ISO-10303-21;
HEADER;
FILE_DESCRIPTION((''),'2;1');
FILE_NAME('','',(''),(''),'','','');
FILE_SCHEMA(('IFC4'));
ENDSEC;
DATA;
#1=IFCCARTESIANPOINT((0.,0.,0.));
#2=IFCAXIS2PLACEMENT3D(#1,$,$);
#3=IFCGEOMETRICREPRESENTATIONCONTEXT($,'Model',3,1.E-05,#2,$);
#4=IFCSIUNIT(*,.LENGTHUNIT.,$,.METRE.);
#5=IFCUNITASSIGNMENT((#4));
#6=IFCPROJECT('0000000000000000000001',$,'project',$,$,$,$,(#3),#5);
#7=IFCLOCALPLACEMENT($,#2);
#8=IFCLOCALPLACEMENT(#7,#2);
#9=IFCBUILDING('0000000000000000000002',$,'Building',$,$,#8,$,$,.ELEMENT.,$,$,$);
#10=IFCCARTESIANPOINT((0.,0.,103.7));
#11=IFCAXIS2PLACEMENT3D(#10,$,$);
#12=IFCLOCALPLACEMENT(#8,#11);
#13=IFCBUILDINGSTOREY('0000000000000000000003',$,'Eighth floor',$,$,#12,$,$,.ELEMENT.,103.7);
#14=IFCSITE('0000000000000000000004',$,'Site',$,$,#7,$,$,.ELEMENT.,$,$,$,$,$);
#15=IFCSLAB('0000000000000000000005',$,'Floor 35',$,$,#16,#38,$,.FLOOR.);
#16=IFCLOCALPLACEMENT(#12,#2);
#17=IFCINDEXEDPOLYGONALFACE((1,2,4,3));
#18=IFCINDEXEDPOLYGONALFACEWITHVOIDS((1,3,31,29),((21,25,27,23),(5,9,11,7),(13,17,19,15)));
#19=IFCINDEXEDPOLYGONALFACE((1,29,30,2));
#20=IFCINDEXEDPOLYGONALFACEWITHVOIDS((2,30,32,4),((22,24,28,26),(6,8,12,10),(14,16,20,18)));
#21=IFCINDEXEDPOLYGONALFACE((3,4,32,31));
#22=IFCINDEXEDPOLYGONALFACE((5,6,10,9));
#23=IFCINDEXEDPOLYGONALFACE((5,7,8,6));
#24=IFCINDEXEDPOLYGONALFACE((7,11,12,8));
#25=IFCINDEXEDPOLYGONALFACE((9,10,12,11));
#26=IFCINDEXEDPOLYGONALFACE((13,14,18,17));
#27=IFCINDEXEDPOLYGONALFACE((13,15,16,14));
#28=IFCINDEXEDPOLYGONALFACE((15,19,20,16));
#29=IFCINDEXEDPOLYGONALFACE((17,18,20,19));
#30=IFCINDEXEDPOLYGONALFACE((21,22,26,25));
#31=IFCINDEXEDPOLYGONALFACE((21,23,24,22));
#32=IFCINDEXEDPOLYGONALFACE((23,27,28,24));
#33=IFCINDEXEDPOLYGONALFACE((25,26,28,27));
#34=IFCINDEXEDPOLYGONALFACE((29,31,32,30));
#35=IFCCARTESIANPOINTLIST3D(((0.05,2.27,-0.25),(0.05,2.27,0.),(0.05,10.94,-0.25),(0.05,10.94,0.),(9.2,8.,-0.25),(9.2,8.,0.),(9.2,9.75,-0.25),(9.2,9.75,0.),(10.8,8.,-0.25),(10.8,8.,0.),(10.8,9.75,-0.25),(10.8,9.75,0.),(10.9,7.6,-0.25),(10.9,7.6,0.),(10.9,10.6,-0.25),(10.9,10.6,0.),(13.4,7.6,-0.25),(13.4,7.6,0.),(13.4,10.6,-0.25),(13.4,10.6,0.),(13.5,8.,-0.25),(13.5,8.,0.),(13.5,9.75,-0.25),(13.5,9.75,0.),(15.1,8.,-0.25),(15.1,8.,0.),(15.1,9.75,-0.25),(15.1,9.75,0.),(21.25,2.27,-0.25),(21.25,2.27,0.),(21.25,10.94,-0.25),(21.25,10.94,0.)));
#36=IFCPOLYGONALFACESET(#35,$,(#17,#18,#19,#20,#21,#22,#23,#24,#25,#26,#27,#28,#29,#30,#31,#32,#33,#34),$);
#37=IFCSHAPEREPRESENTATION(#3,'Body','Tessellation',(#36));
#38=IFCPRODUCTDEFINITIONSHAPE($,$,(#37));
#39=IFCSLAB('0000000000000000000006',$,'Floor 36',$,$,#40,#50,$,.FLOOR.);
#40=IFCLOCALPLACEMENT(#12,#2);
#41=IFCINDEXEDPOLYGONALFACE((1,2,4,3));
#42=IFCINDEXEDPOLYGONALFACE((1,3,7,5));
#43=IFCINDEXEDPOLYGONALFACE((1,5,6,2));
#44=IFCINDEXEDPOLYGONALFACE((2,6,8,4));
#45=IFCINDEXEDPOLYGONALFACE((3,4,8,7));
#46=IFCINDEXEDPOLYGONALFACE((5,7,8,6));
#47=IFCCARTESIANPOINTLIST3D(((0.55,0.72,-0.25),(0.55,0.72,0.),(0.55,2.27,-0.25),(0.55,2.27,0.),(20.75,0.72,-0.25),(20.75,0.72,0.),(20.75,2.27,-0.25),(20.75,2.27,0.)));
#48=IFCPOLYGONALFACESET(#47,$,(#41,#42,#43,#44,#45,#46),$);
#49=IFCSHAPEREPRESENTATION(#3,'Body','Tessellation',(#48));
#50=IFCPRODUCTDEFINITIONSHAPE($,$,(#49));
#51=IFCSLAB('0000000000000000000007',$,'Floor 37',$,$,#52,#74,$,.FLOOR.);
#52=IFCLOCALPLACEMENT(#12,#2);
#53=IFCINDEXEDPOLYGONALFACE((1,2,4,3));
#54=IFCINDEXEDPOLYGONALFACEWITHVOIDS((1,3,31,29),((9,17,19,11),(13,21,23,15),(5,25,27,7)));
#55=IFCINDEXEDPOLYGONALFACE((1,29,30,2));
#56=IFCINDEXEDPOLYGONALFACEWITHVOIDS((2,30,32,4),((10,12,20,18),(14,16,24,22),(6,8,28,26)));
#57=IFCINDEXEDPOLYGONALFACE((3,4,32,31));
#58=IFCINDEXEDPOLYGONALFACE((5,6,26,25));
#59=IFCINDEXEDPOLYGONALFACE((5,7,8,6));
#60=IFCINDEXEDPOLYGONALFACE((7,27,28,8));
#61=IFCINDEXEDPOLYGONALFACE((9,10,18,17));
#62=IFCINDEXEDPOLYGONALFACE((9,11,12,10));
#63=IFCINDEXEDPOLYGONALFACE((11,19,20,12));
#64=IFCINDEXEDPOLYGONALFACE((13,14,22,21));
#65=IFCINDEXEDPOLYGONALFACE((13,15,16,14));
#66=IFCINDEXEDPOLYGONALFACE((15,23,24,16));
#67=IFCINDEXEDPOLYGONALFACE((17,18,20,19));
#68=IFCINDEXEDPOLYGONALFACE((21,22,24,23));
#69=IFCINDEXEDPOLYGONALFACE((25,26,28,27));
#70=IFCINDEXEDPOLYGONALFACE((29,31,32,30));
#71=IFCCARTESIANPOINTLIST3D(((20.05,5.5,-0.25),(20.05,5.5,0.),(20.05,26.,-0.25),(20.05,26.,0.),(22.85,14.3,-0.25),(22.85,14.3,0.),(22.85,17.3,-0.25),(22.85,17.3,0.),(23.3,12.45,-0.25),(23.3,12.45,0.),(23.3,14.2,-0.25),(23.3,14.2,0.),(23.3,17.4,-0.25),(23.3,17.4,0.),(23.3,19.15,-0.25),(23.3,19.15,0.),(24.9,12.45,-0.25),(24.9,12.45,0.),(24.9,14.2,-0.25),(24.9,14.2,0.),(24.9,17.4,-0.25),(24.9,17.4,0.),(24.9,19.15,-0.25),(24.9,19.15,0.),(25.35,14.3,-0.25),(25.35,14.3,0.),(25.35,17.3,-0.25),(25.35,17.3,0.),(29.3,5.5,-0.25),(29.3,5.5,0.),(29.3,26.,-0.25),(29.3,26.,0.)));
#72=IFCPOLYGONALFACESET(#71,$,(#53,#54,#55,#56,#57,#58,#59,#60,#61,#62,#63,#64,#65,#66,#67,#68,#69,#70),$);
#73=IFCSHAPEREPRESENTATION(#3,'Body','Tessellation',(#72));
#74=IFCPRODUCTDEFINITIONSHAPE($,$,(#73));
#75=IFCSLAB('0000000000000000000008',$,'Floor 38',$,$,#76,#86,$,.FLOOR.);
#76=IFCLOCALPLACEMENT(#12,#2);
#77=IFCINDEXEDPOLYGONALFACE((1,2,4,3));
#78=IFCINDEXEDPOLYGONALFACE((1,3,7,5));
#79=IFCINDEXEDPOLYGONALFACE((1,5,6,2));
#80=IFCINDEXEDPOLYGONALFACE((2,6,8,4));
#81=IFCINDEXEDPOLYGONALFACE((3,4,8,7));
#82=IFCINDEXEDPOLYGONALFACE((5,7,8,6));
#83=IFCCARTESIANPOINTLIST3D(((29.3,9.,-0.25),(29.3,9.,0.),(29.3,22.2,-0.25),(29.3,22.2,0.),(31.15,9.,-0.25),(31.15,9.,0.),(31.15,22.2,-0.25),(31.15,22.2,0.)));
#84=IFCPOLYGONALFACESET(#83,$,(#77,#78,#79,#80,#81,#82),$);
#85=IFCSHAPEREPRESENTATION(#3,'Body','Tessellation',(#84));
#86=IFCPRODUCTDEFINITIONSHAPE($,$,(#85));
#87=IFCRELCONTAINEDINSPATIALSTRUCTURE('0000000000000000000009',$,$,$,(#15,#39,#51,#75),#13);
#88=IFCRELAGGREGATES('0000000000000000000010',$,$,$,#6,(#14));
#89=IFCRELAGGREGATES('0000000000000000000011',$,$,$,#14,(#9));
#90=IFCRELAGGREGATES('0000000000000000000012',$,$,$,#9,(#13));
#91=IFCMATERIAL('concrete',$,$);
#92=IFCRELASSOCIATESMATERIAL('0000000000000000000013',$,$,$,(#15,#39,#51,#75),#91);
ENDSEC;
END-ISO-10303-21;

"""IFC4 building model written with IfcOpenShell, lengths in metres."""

from ifc_helpers import new_model, si_unit, frame, origin, place, context, project, spatial, polyline, outline, extrude, material, element, save


model = new_model("IFC4")

# Units and contexts
model_context = context("Model", 3, precision=1e-05, world=origin())
ifc_project = project(units=[si_unit("LENGTHUNIT", "METRE")], contexts=[model_context])

# Site, building, storey
site_placement = place(None, origin())
site = spatial("IfcSite", under=ifc_project, at=site_placement, Name="Site", CompositionType="ELEMENT")
building_placement = place(site_placement, origin())
building = spatial("IfcBuilding", under=site, at=building_placement, Name="Building", CompositionType="ELEMENT")
storey_placement = place(building_placement, frame((0.0, 0.0, 103.7)))
storey = spatial("IfcBuildingStorey", under=building, at=storey_placement, Name="Eighth floor", CompositionType="ELEMENT", Elevation=103.7)

# Slabs
ifc_material = material(Name="concrete")
slab_1_placement = place(storey_placement, frame((0.0, 0.0, -0.25), z_axis=(0.0, 0.0, 1.0), x_axis=(1.0, 0.0, 0.0)))
element("IfcSlab", 1, at=slab_1_placement, inside=storey, material=ifc_material, Name="Floor 35", PredefinedType="FLOOR", context=model_context, shape_type="SweptSolid", body=[
    extrude(outline(polyline([(0.05, 2.27), (21.25, 2.27), (21.25, 10.94), (0.05, 10.94), (0.05, 2.27)]), holes=[polyline([(10.9, 7.6), (13.4, 7.6), (13.4, 10.6), (10.9, 10.6), (10.9, 7.6)]), polyline([(9.2, 8.0), (10.8, 8.0), (10.8, 9.75), (9.2, 9.75), (9.2, 8.0)]), polyline([(13.5, 8.0), (15.1, 8.0), (15.1, 9.75), (13.5, 9.75), (13.5, 8.0)])]), origin(), (0.0, 0.0, 1.0), 0.25),
])
slab_2_placement = place(storey_placement, frame((0.0, 0.0, -0.25), z_axis=(0.0, 0.0, 1.0), x_axis=(1.0, 0.0, 0.0)))
element("IfcSlab", 2, at=slab_2_placement, inside=storey, material=ifc_material, Name="Floor 36", PredefinedType="FLOOR", context=model_context, shape_type="SweptSolid", body=[
    extrude(outline(polyline([(0.55, 0.72), (20.75, 0.72), (20.75, 2.27), (0.55, 2.27), (0.55, 0.72)])), origin(), (0.0, 0.0, 1.0), 0.25),
])
slab_3_placement = place(storey_placement, frame((0.0, 0.0, -0.25), z_axis=(0.0, 0.0, 1.0), x_axis=(1.0, 0.0, 0.0)))
element("IfcSlab", 3, at=slab_3_placement, inside=storey, material=ifc_material, Name="Floor 37", PredefinedType="FLOOR", context=model_context, shape_type="SweptSolid", body=[
    extrude(outline(polyline([(20.05, 5.5), (29.3, 5.5), (29.3, 26.0), (20.05, 26.0), (20.05, 5.5)]), holes=[polyline([(22.85, 14.3), (25.35, 14.3), (25.35, 17.3), (22.85, 17.3), (22.85, 14.3)]), polyline([(23.3, 17.4), (24.9, 17.4), (24.9, 19.15), (23.3, 19.15), (23.3, 17.4)]), polyline([(23.3, 12.45), (24.9, 12.45), (24.9, 14.2), (23.3, 14.2), (23.3, 12.45)])]), origin(), (0.0, 0.0, 1.0), 0.25),
])
slab_4_placement = place(storey_placement, frame((0.0, 0.0, -0.25), z_axis=(0.0, 0.0, 1.0), x_axis=(1.0, 0.0, 0.0)))
element("IfcSlab", 4, at=slab_4_placement, inside=storey, material=ifc_material, Name="Floor 38", PredefinedType="FLOOR", context=model_context, shape_type="SweptSolid", body=[
    extrude(outline(polyline([(29.3, 9.0), (31.15, 9.0), (31.15, 22.2), (29.3, 22.2), (29.3, 9.0)])), origin(), (0.0, 0.0, 1.0), 0.25),
])

save(model, "model.ifc")
